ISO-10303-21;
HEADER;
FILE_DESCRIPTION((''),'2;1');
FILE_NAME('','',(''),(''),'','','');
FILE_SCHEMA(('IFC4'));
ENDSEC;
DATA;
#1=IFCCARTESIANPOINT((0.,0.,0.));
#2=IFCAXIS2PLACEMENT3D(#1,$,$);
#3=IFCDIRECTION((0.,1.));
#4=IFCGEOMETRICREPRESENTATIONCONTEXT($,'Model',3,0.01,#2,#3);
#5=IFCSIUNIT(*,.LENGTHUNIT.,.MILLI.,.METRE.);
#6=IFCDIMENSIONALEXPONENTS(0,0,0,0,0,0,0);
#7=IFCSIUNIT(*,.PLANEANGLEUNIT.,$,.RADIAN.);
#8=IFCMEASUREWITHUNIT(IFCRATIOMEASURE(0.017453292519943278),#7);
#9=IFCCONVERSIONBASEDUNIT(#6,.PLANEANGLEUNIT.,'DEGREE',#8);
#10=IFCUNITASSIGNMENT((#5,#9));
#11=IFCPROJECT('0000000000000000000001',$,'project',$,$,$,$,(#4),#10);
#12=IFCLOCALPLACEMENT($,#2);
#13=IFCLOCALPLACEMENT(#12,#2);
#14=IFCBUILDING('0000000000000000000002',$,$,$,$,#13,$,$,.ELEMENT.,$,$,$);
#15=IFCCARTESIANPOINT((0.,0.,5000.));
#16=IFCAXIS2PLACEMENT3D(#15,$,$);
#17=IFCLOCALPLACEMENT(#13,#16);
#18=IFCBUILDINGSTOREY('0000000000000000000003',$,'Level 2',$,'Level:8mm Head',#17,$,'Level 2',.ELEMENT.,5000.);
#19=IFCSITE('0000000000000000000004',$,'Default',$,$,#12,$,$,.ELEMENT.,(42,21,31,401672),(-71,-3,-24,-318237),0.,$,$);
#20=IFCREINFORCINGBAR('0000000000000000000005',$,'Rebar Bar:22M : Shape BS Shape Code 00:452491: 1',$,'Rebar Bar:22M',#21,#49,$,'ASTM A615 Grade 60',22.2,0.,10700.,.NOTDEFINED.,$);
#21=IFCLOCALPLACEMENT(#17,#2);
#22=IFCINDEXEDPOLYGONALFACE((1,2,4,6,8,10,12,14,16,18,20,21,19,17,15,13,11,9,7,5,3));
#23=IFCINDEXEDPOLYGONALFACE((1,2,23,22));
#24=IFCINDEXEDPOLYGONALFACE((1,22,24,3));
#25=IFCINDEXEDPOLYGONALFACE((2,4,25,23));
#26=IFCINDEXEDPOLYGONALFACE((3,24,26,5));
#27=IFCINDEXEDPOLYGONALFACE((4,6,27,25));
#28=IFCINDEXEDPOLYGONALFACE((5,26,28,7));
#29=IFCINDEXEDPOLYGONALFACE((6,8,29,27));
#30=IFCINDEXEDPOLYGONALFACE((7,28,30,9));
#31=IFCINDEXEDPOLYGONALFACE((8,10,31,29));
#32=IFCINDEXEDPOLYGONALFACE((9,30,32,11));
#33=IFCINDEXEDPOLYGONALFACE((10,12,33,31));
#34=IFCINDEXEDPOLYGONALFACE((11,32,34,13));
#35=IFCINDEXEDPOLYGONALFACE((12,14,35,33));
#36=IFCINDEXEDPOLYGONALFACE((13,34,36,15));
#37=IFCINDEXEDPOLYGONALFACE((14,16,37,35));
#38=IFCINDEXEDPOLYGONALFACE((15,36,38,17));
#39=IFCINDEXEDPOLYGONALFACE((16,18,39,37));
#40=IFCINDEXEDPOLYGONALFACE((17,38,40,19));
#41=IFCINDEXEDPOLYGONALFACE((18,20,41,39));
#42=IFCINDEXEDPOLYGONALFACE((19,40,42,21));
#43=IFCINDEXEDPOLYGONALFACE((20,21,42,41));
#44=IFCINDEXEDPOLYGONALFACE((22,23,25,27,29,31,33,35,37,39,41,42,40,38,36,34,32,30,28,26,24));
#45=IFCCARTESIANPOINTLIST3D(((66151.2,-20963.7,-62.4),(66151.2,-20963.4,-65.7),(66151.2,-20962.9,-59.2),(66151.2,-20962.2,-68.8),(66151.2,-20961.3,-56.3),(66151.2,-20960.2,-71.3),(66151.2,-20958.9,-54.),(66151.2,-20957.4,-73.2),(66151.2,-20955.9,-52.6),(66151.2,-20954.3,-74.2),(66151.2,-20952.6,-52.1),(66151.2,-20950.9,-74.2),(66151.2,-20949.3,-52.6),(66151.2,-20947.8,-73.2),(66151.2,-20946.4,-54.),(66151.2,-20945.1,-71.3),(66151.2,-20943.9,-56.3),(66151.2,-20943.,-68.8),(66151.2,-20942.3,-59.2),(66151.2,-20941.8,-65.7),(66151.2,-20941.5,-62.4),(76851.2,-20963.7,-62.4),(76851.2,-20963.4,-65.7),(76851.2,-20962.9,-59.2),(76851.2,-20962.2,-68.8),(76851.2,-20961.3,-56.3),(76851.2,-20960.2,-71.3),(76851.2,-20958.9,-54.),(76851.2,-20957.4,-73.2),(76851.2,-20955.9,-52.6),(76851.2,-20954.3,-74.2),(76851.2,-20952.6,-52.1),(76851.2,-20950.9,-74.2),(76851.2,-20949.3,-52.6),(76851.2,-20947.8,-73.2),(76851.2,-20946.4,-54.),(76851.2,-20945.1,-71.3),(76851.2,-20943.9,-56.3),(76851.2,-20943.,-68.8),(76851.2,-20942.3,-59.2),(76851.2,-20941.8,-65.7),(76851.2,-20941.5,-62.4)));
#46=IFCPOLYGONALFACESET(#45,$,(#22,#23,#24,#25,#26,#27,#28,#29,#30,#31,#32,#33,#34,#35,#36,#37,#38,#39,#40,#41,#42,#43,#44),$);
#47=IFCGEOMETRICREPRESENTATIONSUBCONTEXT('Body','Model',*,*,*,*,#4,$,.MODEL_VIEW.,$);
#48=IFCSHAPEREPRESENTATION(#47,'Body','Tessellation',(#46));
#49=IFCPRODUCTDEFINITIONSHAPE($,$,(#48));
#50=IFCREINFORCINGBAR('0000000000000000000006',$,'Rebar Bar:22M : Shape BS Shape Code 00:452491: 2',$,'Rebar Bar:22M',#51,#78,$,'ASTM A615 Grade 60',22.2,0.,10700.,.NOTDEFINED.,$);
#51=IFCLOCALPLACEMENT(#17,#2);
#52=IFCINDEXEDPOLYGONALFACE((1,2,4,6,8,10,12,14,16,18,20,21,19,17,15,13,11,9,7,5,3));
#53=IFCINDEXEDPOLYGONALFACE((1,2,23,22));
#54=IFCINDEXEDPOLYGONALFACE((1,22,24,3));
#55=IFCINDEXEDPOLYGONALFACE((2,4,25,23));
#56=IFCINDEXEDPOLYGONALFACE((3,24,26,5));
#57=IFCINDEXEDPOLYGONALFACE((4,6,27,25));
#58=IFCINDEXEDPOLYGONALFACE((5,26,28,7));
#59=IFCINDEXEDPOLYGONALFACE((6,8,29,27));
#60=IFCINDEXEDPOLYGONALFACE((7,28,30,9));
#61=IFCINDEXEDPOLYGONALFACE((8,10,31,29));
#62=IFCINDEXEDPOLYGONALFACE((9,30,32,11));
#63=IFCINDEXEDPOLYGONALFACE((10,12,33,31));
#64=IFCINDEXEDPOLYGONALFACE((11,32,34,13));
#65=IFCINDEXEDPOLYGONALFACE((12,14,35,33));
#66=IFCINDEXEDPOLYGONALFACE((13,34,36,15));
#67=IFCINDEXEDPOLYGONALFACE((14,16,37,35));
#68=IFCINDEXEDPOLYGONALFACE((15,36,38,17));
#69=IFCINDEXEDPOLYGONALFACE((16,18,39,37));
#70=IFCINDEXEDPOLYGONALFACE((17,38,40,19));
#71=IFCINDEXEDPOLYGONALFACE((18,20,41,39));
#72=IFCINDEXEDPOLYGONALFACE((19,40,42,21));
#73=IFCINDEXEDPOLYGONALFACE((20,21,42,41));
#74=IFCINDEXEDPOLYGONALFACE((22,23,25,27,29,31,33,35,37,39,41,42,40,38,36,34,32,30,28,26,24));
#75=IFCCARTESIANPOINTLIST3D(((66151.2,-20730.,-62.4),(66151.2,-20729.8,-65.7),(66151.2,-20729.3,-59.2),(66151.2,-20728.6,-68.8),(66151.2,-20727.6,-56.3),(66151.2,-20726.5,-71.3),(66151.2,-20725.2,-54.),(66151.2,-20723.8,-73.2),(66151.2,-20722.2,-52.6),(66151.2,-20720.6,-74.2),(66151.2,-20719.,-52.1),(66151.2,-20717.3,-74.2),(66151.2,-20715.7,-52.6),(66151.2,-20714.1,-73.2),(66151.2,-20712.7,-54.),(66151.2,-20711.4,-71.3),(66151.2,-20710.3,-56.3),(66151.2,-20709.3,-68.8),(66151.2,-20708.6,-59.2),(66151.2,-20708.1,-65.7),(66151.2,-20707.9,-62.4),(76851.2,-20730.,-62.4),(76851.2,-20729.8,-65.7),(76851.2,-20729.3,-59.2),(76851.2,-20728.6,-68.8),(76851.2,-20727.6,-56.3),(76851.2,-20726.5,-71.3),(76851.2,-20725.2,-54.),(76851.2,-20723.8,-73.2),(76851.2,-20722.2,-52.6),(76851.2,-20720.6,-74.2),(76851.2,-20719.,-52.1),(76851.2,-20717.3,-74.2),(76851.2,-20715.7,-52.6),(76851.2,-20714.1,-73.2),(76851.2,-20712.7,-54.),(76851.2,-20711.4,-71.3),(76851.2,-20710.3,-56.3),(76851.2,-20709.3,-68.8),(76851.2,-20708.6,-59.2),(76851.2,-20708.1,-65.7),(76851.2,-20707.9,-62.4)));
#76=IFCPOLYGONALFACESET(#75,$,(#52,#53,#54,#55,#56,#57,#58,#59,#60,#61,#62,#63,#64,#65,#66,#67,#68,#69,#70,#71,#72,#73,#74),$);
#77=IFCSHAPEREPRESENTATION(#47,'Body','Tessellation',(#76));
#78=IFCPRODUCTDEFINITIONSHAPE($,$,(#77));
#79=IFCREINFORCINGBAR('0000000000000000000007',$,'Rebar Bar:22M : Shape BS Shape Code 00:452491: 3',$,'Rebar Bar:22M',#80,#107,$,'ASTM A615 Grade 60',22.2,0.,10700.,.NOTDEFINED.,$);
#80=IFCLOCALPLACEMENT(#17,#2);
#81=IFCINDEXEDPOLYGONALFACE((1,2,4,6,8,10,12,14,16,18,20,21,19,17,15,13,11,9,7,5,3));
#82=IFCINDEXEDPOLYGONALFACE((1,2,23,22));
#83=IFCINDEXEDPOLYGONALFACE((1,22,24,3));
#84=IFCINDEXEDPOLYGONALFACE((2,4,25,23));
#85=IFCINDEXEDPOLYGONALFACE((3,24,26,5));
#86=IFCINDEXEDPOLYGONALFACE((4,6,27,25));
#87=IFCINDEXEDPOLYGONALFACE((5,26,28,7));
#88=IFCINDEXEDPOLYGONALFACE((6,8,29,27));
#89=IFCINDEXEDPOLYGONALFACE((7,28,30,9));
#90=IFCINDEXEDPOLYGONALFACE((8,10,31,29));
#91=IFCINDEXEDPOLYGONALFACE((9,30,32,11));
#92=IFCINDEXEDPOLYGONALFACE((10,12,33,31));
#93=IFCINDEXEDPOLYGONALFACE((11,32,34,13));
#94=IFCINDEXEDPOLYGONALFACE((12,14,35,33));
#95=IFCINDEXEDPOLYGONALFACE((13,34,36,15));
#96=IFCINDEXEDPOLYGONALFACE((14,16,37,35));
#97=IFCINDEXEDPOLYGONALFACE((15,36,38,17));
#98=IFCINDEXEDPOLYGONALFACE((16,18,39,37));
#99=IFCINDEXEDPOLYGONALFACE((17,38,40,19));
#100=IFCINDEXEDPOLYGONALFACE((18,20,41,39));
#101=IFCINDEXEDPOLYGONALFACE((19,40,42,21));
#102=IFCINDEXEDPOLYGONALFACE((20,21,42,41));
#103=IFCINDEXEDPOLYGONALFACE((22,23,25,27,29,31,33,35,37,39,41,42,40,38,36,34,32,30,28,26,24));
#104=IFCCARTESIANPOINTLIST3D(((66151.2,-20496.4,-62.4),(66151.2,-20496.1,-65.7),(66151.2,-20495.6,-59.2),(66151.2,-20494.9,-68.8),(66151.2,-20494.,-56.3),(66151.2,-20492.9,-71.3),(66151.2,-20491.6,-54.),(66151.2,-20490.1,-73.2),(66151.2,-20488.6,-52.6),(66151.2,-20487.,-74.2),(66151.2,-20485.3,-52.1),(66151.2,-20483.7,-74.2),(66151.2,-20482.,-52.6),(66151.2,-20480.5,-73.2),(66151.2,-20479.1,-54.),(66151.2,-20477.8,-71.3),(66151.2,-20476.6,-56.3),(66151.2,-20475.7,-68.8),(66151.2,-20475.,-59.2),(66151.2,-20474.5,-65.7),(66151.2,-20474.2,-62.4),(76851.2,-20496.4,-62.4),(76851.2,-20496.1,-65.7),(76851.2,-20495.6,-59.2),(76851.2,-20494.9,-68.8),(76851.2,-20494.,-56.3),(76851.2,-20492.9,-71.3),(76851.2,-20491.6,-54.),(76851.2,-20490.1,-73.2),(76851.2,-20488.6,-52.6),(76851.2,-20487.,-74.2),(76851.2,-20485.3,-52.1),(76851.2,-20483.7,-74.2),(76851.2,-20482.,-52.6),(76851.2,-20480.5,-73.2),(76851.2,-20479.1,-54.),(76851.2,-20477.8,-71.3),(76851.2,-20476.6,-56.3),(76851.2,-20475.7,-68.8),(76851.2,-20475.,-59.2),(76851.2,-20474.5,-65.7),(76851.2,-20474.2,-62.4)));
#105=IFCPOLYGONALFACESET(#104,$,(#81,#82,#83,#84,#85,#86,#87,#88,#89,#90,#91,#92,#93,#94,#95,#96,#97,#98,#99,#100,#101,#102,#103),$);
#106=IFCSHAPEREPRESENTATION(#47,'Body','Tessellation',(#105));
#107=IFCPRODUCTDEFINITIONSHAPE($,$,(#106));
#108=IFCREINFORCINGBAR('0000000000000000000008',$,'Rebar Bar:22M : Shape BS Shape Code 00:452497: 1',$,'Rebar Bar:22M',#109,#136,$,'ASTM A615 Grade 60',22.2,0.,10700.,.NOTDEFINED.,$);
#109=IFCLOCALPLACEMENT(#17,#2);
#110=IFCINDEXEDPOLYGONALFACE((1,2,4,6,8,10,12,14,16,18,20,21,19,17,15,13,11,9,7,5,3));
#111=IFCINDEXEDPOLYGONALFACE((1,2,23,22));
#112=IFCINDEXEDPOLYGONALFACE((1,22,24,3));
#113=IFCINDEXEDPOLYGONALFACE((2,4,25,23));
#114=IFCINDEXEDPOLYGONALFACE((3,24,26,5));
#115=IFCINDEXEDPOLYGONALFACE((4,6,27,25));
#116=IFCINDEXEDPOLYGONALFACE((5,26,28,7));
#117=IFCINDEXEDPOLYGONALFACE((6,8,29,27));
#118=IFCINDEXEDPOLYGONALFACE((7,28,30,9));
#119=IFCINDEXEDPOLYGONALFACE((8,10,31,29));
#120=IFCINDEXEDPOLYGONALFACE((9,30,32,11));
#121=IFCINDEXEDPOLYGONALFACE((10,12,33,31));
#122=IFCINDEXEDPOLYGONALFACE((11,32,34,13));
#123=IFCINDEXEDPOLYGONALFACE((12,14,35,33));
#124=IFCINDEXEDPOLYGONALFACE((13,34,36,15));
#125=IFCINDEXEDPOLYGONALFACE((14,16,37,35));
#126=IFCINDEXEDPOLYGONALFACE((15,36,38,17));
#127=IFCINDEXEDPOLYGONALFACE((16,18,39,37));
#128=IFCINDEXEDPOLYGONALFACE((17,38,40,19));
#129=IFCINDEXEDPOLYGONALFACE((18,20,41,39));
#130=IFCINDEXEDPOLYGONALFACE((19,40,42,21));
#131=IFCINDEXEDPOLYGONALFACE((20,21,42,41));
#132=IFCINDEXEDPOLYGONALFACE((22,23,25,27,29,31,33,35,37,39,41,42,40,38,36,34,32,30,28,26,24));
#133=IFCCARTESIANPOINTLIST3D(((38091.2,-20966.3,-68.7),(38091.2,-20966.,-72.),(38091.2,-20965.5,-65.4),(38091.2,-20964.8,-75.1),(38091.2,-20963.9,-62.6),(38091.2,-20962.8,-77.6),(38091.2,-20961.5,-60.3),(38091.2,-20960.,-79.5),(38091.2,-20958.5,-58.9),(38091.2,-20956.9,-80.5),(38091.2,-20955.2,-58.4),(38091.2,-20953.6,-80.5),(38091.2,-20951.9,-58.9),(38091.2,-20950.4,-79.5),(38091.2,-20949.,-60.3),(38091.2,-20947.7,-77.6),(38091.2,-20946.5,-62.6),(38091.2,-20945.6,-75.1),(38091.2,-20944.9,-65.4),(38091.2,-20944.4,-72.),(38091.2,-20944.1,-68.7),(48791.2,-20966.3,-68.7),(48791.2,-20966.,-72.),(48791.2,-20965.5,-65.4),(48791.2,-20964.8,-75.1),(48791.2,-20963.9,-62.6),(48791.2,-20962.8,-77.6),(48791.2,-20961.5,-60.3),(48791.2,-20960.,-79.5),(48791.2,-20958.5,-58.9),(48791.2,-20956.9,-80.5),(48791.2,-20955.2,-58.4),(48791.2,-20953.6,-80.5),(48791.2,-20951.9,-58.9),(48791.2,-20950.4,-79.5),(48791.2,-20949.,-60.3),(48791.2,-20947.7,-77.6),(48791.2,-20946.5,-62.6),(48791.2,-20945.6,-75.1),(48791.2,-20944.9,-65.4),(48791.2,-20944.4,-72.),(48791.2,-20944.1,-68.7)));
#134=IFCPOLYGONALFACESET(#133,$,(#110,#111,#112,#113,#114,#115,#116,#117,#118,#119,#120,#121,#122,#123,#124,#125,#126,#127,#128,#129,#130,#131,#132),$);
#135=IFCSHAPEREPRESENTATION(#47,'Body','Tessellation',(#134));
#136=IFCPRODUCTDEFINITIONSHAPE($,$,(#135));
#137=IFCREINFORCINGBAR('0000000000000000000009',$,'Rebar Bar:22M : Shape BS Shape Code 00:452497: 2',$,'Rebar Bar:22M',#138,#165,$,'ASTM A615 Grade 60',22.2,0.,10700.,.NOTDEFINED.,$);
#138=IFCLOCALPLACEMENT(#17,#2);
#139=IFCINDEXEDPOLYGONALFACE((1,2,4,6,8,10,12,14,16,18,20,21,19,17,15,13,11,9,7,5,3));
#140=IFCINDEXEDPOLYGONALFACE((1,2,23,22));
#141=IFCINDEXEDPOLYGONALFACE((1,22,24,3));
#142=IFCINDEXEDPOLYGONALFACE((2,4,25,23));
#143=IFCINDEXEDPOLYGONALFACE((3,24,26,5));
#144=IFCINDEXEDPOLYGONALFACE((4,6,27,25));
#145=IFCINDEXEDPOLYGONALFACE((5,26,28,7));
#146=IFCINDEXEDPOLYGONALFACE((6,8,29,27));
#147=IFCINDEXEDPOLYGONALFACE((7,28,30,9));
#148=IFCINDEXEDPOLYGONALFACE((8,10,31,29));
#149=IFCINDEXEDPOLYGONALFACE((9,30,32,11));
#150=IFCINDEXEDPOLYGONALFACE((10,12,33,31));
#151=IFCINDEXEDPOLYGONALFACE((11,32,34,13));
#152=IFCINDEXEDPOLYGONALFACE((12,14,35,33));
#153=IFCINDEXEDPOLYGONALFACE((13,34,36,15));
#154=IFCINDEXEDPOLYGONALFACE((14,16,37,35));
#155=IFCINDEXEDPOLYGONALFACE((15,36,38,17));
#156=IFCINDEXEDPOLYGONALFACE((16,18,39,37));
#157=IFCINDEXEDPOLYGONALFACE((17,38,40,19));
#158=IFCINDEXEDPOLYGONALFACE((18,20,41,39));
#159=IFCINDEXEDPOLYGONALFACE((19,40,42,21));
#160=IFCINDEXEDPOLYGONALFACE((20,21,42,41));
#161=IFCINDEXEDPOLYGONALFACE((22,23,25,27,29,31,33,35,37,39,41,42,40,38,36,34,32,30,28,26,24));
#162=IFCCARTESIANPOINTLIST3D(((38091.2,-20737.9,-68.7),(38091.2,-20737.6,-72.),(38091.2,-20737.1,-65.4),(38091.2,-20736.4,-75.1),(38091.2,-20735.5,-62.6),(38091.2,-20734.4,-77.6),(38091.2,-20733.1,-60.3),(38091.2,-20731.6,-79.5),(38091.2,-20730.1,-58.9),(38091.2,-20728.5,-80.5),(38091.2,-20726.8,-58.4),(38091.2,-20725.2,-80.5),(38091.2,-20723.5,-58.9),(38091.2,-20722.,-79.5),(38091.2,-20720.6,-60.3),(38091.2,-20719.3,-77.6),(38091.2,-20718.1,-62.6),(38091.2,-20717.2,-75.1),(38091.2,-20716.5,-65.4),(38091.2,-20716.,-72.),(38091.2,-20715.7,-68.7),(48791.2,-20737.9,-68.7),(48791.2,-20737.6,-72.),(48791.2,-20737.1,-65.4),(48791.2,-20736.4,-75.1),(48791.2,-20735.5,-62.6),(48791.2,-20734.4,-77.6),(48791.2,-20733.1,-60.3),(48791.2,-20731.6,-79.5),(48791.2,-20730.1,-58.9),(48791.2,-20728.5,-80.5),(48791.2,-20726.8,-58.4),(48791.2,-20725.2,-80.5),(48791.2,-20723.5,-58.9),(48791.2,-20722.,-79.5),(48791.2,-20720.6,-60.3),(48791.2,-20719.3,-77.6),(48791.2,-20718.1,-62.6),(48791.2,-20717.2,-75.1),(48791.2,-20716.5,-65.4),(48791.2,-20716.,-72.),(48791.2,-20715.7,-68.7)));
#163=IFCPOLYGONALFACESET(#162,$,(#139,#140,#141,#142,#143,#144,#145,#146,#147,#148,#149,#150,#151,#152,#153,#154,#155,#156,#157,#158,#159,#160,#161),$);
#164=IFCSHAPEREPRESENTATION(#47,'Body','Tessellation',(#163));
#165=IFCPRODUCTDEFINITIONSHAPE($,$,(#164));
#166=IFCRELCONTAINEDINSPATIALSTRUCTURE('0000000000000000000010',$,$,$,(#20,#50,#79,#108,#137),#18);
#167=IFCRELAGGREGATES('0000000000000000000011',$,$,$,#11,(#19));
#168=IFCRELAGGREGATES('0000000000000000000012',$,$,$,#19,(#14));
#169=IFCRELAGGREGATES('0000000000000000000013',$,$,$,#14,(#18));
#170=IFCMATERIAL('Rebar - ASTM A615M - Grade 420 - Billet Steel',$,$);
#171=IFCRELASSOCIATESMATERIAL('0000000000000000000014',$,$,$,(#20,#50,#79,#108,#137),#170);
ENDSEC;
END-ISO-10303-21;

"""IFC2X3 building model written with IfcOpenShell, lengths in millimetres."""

from ifc_helpers import new_model, entity, si_unit, converted_unit, direction, frame, origin, place, context, subcontext, project, spatial, material, element, save


model = new_model("IFC2X3")

# Units and contexts
model_context = context("Model", 3, precision=0.01, world=origin(), true_north=direction((0.0, 1.0)))
body_context = subcontext(model_context, "Body", "Model", "MODEL_VIEW")
ifc_project = project(units=[si_unit("LENGTHUNIT", "METRE", prefix="MILLI"), converted_unit("PLANEANGLEUNIT", "DEGREE", entity("IfcRatioMeasure", 0.017453292519943278), si_unit("PLANEANGLEUNIT", "RADIAN"), dimensions=[0, 0, 0, 0, 0, 0, 0])], contexts=[model_context])

# Site, building, storey
site_placement = place(None, origin())
site = spatial("IfcSite", under=ifc_project, at=site_placement, Name="Default", CompositionType="ELEMENT", RefLatitude=(42, 21, 31, 401672), RefLongitude=(-71, -3, -24, -318237), RefElevation=0.0)
building_placement = place(site_placement, origin())
building = spatial("IfcBuilding", under=site, at=building_placement, CompositionType="ELEMENT")
storey_placement = place(building_placement, frame((0.0, 0.0, 5000.0)))
storey = spatial("IfcBuildingStorey", under=building, at=storey_placement, Name="Level 2", ObjectType="Level:8mm Head", LongName="Level 2", CompositionType="ELEMENT", Elevation=5000.0)

# Reinforcing bars
ifc_material_1 = material(Name="Rebar - ASTM A615M - Grade 420 - Billet Steel")
reinforcing_bar_1_placement = place(storey_placement, origin())
element("IfcReinforcingBar", 1, at=reinforcing_bar_1_placement, inside=storey, material=ifc_material_1, Name="Rebar Bar:22M : Shape BS Shape Code 00:452491: 1", SteelGrade="ASTM A615 Grade 60", ObjectType="Rebar Bar:22M", BarLength=10700.0, BarRole="NOTDEFINED", CrossSectionArea=0.0, NominalDiameter=22.2, context=body_context, shape_type="AdvancedSweptSolid", body=[
    entity("IfcSweptDiskSolid", entity("IfcCompositeCurve", [entity("IfcCompositeCurveSegment", "CONTINUOUS", True, entity("IfcPolyline", [entity("IfcCartesianPoint", [66151.2, -20952.6, -63.2]), entity("IfcCartesianPoint", [76851.2, -20952.6, -63.2])]))], False), 11.1, None, 0.0, 1.0),
])
reinforcing_bar_2_placement = place(storey_placement, origin())
element("IfcReinforcingBar", 2, at=reinforcing_bar_2_placement, inside=storey, material=ifc_material_1, Name="Rebar Bar:22M : Shape BS Shape Code 00:452491: 2", SteelGrade="ASTM A615 Grade 60", ObjectType="Rebar Bar:22M", BarLength=10700.0, BarRole="NOTDEFINED", CrossSectionArea=0.0, NominalDiameter=22.2, context=body_context, shape_type="AdvancedSweptSolid", body=[
    entity("IfcSweptDiskSolid", entity("IfcCompositeCurve", [entity("IfcCompositeCurveSegment", "CONTINUOUS", True, entity("IfcPolyline", [entity("IfcCartesianPoint", [66151.2, -20719.0, -63.2]), entity("IfcCartesianPoint", [76851.2, -20719.0, -63.2])]))], False), 11.1, None, 0.0, 1.0),
])
reinforcing_bar_3_placement = place(storey_placement, origin())
element("IfcReinforcingBar", 3, at=reinforcing_bar_3_placement, inside=storey, material=ifc_material_1, Name="Rebar Bar:22M : Shape BS Shape Code 00:452491: 3", SteelGrade="ASTM A615 Grade 60", ObjectType="Rebar Bar:22M", BarLength=10700.0, BarRole="NOTDEFINED", CrossSectionArea=0.0, NominalDiameter=22.2, context=body_context, shape_type="AdvancedSweptSolid", body=[
    entity("IfcSweptDiskSolid", entity("IfcCompositeCurve", [entity("IfcCompositeCurveSegment", "CONTINUOUS", True, entity("IfcPolyline", [entity("IfcCartesianPoint", [66151.2, -20485.3, -63.2]), entity("IfcCartesianPoint", [76851.2, -20485.3, -63.2])]))], False), 11.1, None, 0.0, 1.0),
])
reinforcing_bar_4_placement = place(storey_placement, origin())
element("IfcReinforcingBar", 4, at=reinforcing_bar_4_placement, inside=storey, material=ifc_material_1, Name="Rebar Bar:22M : Shape BS Shape Code 00:452497: 1", SteelGrade="ASTM A615 Grade 60", ObjectType="Rebar Bar:22M", BarLength=10700.0, BarRole="NOTDEFINED", CrossSectionArea=0.0, NominalDiameter=22.2, context=body_context, shape_type="AdvancedSweptSolid", body=[
    entity("IfcSweptDiskSolid", entity("IfcCompositeCurve", [entity("IfcCompositeCurveSegment", "CONTINUOUS", True, entity("IfcPolyline", [entity("IfcCartesianPoint", [38091.2, -20955.2, -69.5]), entity("IfcCartesianPoint", [48791.2, -20955.2, -69.5])]))], False), 11.1, None, 0.0, 1.0),
])
reinforcing_bar_5_placement = place(storey_placement, origin())
element("IfcReinforcingBar", 5, at=reinforcing_bar_5_placement, inside=storey, material=ifc_material_1, Name="Rebar Bar:22M : Shape BS Shape Code 00:452497: 2", SteelGrade="ASTM A615 Grade 60", ObjectType="Rebar Bar:22M", BarLength=10700.0, BarRole="NOTDEFINED", CrossSectionArea=0.0, NominalDiameter=22.2, context=body_context, shape_type="AdvancedSweptSolid", body=[
    entity("IfcSweptDiskSolid", entity("IfcCompositeCurve", [entity("IfcCompositeCurveSegment", "CONTINUOUS", True, entity("IfcPolyline", [entity("IfcCartesianPoint", [38091.2, -20726.8, -69.5]), entity("IfcCartesianPoint", [48791.2, -20726.8, -69.5])]))], False), 11.1, None, 0.0, 1.0),
])

save(model, "model.ifc")
